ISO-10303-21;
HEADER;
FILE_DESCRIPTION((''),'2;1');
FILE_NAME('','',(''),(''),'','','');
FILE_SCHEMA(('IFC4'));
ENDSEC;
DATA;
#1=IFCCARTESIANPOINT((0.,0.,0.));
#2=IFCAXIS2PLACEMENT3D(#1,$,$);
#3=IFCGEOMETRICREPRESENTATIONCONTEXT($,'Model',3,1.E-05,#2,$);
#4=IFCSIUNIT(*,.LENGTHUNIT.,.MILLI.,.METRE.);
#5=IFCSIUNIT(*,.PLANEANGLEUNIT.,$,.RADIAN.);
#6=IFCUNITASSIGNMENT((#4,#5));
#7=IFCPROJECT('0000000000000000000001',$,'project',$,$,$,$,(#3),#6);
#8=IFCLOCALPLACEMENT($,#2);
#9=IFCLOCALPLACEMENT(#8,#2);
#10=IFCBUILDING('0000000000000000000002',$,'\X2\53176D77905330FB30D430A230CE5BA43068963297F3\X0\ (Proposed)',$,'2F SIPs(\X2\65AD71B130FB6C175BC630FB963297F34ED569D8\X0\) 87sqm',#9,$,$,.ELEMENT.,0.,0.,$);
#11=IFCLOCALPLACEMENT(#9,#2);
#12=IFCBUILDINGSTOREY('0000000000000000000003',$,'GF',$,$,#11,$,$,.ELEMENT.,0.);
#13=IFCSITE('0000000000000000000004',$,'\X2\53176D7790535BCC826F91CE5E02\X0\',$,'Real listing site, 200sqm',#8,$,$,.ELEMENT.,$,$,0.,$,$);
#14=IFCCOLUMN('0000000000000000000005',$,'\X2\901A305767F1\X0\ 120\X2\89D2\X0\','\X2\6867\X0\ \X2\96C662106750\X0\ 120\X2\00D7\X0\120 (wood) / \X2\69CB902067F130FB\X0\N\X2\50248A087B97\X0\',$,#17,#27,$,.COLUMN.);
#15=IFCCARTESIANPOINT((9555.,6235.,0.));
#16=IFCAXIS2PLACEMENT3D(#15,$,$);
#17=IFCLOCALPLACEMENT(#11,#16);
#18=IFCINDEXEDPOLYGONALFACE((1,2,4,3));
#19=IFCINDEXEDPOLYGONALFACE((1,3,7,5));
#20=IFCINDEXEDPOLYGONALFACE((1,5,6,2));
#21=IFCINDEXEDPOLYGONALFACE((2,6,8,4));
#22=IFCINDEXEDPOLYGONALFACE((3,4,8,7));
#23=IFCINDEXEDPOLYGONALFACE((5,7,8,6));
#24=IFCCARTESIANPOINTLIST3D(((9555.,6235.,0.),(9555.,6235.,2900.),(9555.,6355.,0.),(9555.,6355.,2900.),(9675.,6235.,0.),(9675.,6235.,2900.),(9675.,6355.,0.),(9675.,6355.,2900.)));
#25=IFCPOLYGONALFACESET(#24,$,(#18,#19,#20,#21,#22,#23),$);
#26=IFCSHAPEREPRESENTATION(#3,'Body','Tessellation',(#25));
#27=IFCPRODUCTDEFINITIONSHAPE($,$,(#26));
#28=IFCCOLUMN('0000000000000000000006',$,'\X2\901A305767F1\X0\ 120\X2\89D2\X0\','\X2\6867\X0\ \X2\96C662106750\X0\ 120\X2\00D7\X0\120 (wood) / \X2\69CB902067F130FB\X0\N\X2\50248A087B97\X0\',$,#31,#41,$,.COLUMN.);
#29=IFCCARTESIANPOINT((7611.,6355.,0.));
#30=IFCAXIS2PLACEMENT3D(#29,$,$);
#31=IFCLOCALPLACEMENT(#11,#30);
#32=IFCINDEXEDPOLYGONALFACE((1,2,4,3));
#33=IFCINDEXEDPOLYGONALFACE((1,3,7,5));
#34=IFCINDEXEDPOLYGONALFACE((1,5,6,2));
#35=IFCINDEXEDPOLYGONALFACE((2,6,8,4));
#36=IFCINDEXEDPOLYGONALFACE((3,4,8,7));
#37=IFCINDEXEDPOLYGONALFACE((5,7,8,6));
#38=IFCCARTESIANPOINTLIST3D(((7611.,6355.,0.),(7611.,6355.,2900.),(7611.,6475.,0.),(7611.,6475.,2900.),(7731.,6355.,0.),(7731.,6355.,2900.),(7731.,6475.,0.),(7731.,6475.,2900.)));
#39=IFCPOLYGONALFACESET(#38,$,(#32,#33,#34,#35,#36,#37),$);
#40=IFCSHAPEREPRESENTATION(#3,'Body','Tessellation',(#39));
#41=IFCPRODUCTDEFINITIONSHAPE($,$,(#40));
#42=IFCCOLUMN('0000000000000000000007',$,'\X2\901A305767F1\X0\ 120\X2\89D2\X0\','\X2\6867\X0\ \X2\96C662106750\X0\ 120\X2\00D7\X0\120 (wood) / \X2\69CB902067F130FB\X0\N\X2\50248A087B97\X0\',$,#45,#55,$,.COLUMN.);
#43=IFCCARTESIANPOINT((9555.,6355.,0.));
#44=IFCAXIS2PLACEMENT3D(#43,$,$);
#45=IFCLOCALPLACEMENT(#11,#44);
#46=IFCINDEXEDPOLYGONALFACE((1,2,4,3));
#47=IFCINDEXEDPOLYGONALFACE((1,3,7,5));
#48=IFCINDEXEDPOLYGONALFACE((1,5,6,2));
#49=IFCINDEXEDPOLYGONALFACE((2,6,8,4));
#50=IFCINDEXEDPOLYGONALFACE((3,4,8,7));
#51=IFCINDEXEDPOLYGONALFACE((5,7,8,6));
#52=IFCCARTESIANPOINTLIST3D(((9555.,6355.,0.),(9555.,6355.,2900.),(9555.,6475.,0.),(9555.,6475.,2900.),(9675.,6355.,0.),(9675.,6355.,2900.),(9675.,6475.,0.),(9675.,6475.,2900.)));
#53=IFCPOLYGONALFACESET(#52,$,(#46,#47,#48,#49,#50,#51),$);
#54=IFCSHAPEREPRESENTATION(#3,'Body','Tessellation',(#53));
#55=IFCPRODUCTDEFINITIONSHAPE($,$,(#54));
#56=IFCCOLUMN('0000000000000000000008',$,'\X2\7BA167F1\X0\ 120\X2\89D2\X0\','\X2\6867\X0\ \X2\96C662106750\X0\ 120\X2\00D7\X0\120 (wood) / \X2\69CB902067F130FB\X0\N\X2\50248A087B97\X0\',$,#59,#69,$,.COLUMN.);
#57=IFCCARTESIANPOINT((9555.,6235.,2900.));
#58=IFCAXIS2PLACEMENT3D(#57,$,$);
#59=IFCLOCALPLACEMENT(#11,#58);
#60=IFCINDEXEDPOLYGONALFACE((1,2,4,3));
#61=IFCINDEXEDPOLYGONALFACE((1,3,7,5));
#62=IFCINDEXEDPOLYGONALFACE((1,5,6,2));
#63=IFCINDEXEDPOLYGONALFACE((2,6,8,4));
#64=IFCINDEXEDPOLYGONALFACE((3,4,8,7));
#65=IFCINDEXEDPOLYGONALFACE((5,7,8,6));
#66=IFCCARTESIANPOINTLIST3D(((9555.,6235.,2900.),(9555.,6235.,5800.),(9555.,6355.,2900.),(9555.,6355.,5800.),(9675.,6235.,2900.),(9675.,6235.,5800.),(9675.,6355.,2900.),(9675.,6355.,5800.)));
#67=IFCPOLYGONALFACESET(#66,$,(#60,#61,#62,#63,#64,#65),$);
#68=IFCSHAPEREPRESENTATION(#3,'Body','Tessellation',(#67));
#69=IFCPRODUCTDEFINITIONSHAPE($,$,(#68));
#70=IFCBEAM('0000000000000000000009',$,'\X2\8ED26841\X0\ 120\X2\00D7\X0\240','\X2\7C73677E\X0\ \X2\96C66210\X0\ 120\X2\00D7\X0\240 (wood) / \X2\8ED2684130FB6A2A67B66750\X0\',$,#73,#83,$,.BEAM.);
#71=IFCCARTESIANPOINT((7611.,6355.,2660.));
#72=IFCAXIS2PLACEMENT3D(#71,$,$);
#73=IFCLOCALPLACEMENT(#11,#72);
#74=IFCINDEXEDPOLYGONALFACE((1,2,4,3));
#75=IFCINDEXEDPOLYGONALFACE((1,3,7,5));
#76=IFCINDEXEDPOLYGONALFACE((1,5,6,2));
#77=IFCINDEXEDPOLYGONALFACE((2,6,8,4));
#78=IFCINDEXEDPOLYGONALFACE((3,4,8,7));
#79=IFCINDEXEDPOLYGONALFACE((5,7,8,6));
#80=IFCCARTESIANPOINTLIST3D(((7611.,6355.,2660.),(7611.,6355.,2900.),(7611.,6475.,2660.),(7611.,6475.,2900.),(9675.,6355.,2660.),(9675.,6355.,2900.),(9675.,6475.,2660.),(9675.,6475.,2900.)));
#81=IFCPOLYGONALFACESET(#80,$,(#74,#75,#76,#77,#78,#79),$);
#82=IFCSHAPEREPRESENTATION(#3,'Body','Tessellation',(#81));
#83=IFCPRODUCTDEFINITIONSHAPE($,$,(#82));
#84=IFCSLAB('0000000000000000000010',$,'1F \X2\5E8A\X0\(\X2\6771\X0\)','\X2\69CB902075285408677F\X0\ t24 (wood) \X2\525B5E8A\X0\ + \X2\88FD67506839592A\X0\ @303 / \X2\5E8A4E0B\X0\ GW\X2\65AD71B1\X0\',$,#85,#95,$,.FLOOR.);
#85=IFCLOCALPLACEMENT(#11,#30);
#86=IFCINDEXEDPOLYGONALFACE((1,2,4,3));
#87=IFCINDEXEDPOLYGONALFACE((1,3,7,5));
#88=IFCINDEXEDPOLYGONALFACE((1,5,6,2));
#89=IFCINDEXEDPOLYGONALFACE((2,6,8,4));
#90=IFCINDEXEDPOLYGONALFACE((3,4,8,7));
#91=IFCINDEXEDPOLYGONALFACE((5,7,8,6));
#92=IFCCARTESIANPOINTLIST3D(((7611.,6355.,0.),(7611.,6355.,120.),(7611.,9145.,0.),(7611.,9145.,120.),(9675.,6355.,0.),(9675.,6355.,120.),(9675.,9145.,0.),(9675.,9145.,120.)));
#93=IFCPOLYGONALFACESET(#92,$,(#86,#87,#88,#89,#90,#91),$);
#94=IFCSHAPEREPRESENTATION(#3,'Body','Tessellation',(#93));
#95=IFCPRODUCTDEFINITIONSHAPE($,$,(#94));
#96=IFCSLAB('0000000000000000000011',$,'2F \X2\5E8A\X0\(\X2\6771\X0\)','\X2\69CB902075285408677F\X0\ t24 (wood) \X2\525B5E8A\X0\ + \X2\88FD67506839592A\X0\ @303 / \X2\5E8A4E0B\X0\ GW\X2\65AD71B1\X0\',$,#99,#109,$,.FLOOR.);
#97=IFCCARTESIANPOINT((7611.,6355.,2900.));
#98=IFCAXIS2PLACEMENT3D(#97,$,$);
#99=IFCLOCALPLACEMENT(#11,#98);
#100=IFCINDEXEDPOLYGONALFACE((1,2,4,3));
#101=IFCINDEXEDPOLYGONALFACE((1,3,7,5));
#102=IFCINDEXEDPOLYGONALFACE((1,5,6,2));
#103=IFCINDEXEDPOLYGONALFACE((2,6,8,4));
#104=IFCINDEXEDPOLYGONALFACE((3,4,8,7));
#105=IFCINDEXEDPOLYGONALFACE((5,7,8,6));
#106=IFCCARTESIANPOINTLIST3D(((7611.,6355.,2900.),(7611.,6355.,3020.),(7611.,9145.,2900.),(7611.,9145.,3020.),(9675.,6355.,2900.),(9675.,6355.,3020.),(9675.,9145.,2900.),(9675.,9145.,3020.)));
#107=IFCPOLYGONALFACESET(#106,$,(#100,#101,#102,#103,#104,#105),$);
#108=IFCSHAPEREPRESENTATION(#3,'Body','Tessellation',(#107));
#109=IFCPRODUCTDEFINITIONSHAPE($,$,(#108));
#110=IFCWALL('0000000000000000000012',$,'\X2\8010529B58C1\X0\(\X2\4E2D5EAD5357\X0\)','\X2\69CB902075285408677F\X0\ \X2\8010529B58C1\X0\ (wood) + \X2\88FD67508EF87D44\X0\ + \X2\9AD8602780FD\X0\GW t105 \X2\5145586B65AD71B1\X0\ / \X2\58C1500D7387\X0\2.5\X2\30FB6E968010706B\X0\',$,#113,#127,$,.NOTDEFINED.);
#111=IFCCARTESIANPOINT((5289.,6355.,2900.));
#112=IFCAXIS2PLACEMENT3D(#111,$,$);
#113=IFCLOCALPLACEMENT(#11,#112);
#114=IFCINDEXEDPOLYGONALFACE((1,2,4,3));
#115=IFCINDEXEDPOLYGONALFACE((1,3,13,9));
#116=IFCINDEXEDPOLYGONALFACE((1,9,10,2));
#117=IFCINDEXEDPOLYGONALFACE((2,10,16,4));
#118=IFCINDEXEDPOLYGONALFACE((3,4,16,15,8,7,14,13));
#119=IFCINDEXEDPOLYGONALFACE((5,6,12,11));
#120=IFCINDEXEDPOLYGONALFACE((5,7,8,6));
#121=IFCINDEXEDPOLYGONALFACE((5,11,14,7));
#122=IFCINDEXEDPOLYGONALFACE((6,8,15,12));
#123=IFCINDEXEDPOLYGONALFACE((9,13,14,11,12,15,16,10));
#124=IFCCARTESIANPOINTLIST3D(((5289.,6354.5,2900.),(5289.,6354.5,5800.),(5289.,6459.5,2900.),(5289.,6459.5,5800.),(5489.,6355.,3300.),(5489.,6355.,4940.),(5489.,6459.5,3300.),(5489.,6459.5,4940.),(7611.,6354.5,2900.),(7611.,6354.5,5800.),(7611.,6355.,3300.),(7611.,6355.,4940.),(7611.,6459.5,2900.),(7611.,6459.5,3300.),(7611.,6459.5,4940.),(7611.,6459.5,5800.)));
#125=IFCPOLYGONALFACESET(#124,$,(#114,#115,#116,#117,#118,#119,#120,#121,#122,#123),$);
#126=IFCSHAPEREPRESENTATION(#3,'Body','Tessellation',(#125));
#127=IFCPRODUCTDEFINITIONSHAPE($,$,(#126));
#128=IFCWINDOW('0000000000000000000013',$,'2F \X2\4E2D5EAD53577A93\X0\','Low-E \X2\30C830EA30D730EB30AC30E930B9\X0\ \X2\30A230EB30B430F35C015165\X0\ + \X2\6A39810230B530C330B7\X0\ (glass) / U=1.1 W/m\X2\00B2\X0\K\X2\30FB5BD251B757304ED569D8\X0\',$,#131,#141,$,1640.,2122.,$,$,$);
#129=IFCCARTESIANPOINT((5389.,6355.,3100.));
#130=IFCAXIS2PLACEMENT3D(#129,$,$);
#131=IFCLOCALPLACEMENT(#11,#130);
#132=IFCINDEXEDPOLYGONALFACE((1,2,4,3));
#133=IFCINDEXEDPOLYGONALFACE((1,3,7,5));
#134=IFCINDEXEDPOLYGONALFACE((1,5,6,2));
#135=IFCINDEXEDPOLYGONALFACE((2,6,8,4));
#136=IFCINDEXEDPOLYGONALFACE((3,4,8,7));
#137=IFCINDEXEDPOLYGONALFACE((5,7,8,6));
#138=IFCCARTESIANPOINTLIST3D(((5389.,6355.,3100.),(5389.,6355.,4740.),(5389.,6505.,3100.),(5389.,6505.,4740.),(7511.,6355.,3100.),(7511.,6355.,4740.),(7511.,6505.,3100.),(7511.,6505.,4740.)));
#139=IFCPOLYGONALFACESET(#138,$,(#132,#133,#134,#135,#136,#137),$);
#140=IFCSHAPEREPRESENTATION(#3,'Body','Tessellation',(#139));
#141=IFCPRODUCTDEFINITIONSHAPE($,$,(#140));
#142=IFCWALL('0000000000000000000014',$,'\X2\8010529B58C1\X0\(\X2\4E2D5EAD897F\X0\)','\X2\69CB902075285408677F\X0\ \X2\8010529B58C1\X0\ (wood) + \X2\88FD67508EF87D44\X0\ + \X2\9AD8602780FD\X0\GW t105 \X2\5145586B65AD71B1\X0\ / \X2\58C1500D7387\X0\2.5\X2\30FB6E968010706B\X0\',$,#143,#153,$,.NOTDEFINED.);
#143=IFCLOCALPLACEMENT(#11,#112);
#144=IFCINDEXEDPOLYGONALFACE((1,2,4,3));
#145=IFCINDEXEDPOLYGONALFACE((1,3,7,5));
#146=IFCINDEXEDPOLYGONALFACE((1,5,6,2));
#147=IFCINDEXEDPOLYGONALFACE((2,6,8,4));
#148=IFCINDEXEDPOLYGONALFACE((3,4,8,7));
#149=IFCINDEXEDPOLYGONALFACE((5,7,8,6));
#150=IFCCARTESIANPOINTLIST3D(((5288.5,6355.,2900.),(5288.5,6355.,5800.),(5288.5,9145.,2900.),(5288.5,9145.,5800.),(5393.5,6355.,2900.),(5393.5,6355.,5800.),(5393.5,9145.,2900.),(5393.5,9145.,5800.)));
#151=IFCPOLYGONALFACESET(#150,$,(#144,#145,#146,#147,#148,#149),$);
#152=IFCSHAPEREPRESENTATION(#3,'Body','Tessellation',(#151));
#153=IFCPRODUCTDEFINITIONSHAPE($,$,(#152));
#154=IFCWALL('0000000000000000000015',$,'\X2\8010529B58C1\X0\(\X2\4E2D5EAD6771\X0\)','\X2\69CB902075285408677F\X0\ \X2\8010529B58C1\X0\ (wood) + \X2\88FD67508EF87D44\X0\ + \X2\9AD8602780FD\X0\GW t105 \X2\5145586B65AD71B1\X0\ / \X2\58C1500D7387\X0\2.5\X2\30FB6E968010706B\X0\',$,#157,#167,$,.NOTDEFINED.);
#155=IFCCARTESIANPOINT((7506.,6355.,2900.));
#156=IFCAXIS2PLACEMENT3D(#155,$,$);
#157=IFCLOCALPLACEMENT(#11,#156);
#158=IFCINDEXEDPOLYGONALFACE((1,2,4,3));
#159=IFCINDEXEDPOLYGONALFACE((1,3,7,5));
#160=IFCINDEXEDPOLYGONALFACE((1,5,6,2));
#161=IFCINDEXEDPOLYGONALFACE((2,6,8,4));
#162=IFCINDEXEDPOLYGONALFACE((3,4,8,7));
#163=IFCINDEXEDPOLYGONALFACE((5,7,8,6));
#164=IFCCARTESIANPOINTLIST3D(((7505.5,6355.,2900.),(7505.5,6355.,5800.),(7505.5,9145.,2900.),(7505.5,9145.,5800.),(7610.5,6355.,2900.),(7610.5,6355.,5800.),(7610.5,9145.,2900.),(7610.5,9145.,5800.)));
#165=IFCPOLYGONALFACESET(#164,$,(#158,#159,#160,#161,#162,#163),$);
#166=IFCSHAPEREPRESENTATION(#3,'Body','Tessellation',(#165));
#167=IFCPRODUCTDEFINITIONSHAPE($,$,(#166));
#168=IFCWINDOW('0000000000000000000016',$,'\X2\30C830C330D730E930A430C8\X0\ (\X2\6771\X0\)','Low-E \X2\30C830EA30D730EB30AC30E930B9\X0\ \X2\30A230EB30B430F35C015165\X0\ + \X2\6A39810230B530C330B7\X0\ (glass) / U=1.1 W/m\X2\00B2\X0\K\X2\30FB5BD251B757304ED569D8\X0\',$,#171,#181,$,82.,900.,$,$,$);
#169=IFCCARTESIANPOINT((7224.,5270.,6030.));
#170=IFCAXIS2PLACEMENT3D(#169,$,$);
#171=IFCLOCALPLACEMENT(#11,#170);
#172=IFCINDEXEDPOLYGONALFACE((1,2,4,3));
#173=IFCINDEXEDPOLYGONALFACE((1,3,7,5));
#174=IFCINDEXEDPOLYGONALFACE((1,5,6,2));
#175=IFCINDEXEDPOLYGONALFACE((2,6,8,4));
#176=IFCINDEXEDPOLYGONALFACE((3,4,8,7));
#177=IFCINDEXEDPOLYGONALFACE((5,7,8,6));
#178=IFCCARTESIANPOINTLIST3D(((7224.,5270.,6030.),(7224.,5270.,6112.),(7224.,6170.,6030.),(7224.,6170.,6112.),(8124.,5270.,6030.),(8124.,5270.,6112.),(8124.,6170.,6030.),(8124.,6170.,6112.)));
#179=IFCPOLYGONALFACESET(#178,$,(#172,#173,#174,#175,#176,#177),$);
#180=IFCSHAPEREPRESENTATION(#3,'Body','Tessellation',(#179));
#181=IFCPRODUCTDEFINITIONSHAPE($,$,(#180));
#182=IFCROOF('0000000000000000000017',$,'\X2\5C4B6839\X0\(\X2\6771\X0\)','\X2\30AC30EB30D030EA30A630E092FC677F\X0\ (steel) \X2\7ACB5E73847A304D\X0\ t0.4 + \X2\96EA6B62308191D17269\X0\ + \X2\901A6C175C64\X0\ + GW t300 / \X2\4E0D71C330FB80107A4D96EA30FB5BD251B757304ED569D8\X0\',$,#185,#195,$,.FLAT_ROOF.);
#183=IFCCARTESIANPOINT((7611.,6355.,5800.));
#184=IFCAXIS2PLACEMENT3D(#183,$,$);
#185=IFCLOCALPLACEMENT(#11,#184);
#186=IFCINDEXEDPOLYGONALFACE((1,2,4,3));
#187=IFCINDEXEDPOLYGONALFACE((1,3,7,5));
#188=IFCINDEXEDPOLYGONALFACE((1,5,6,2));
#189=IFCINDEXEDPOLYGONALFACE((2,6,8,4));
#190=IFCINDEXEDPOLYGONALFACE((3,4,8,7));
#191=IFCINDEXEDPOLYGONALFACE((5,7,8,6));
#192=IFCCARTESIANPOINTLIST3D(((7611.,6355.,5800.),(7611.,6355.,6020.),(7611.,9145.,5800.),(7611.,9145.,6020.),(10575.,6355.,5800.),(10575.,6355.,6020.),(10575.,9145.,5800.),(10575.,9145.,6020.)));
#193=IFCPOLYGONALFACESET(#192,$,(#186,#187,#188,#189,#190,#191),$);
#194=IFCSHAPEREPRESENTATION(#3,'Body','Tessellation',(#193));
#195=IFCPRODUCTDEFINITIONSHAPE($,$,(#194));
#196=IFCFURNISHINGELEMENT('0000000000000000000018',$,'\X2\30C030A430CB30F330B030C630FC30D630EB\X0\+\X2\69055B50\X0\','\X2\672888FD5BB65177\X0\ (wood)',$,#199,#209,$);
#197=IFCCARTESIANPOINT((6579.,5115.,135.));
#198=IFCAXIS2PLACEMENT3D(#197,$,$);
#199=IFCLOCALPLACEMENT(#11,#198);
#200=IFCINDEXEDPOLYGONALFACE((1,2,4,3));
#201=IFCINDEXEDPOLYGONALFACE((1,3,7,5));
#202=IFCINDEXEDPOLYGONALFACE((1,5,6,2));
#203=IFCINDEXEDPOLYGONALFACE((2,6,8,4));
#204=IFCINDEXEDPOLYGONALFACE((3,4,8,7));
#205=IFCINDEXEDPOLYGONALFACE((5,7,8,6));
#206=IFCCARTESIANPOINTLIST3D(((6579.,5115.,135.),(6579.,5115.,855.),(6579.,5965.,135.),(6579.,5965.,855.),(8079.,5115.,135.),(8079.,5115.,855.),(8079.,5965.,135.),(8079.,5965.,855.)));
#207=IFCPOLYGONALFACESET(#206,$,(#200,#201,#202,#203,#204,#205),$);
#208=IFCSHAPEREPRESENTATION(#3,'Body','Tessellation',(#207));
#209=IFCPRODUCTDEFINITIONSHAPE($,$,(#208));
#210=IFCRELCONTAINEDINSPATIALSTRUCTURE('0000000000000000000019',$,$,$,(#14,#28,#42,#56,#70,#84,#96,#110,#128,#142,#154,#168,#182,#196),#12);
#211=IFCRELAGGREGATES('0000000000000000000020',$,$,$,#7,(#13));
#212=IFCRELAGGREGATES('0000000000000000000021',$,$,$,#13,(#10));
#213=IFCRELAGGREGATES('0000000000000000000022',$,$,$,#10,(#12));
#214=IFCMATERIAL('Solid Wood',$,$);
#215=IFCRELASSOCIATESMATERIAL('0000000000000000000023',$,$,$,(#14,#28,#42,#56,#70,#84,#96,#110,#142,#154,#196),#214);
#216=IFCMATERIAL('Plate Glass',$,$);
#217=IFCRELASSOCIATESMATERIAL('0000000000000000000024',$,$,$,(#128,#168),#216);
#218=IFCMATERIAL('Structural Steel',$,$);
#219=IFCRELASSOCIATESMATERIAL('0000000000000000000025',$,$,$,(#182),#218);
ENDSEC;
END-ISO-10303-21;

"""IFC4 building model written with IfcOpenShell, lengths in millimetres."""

from ifc_helpers import new_model, si_unit, frame, frame_2d, origin, place, context, project, spatial, rectangle, extrude, material, element, fill, save


model = new_model("IFC4")

# Units and contexts
model_context = context("Model", 3, precision=1e-05, world=origin())
ifc_project = project(units=[si_unit("LENGTHUNIT", "METRE", prefix="MILLI"), si_unit("PLANEANGLEUNIT", "RADIAN")], contexts=[model_context])

# Site, building, storey
site_placement = place(None, origin())
site = spatial("IfcSite", under=ifc_project, at=site_placement, Name="北海道富良野市", ObjectType="Real listing site, 200sqm", CompositionType="ELEMENT", RefElevation=0.0)
building_placement = place(site_placement, origin())
building = spatial("IfcBuilding", under=site, at=building_placement, Name="北海道・ピアノ室と防音 (Proposed)", ObjectType="2F SIPs(断熱・気密・防音仕様) 87sqm", CompositionType="ELEMENT", ElevationOfRefHeight=0.0, ElevationOfTerrain=0.0)
storey_placement = place(building_placement, origin())
storey = spatial("IfcBuildingStorey", under=building, at=storey_placement, Name="GF", CompositionType="ELEMENT", Elevation=0.0)

# Columns
ifc_material_1 = material(Name="Solid Wood")
column_1_placement = place(storey_placement, frame((9555.0, 6235.0, 0.0)))
element("IfcColumn", 1, at=column_1_placement, inside=storey, material=ifc_material_1, Name="通し柱 120角", Description="桧 集成材 120×120 (wood) / 構造柱・N値計算", PredefinedType="COLUMN", context=model_context, shape_type="SweptSolid", body=[
    extrude(rectangle(XDim=120.0, YDim=120.0, at=frame_2d((60.0, 60.0))), frame((9555.0, 6235.0, 0.0)), (0.0, 0.0, 1.0), 2900.0),
])
column_2_placement = place(storey_placement, frame((7611.0, 6355.0, 0.0)))
element("IfcColumn", 2, at=column_2_placement, inside=storey, material=ifc_material_1, Name="通し柱 120角", Description="桧 集成材 120×120 (wood) / 構造柱・N値計算", PredefinedType="COLUMN", context=model_context, shape_type="SweptSolid", body=[
    extrude(rectangle(XDim=120.0, YDim=120.0, at=frame_2d((60.0, 60.0))), frame((7611.0, 6355.0, 0.0)), (0.0, 0.0, 1.0), 2900.0),
])
column_3_placement = place(storey_placement, frame((9555.0, 6355.0, 0.0)))
element("IfcColumn", 3, at=column_3_placement, inside=storey, material=ifc_material_1, Name="通し柱 120角", Description="桧 集成材 120×120 (wood) / 構造柱・N値計算", PredefinedType="COLUMN", context=model_context, shape_type="SweptSolid", body=[
    extrude(rectangle(XDim=120.0, YDim=120.0, at=frame_2d((60.0, 60.0))), frame((9555.0, 6355.0, 0.0)), (0.0, 0.0, 1.0), 2900.0),
])
column_4_placement = place(storey_placement, frame((9555.0, 6235.0, 2900.0)))
element("IfcColumn", 4, at=column_4_placement, inside=storey, material=ifc_material_1, Name="管柱 120角", Description="桧 集成材 120×120 (wood) / 構造柱・N値計算", PredefinedType="COLUMN", context=model_context, shape_type="SweptSolid", body=[
    extrude(rectangle(XDim=120.0, YDim=120.0, at=frame_2d((60.0, 60.0))), frame((9555.0, 6235.0, 2900.0)), (0.0, 0.0, 1.0), 2900.0),
])

# Beam
beam_1_placement = place(storey_placement, frame((7611.0, 6355.0, 2660.0)))
element("IfcBeam", 5, at=beam_1_placement, inside=storey, material=ifc_material_1, Name="軒桁 120×240", Description="米松 集成 120×240 (wood) / 軒桁・横架材", PredefinedType="BEAM", context=model_context, shape_type="SweptSolid", body=[
    extrude(rectangle(XDim=2064.0, YDim=120.0, at=frame_2d((1032.0, 60.0))), frame((7611.0, 6355.0, 2660.0)), (0.0, 0.0, 1.0), 240.0),
])

# Slabs
slab_1_placement = place(storey_placement, frame((7611.0, 6355.0, 0.0)))
element("IfcSlab", 6, at=slab_1_placement, inside=storey, material=ifc_material_1, Name="1F 床(東)", Description="構造用合板 t24 (wood) 剛床 + 製材根太 @303 / 床下 GW断熱", PredefinedType="FLOOR", context=model_context, shape_type="SweptSolid", body=[
    extrude(rectangle(XDim=2064.0, YDim=2790.0, at=frame_2d((1032.0, 1395.0))), frame((7611.0, 6355.0, 0.0)), (0.0, 0.0, 1.0), 120.0),
])
slab_2_placement = place(storey_placement, frame((7611.0, 6355.0, 2900.0)))
element("IfcSlab", 7, at=slab_2_placement, inside=storey, material=ifc_material_1, Name="2F 床(東)", Description="構造用合板 t24 (wood) 剛床 + 製材根太 @303 / 床下 GW断熱", PredefinedType="FLOOR", context=model_context, shape_type="SweptSolid", body=[
    extrude(rectangle(XDim=2064.0, YDim=2790.0, at=frame_2d((1032.0, 1395.0))), frame((7611.0, 6355.0, 2900.0)), (0.0, 0.0, 1.0), 120.0),
])

# Wall, opening, window
wall_1_placement = place(storey_placement, frame((5289.0, 6355.0, 2900.0)))
wall_1 = element("IfcWall", 8, at=wall_1_placement, inside=storey, material=ifc_material_1, Name="耐力壁(中庭南)", Description="構造用合板 耐力壁 (wood) + 製材軸組 + 高性能GW t105 充填断熱 / 壁倍率2.5・準耐火", PredefinedType="NOTDEFINED", context=model_context, shape_type="SweptSolid", body=[
    extrude(rectangle(XDim=2322.0, YDim=105.0, at=frame_2d((1161.0, 52.0))), frame((5289.0, 6355.0, 2900.0)), (0.0, 0.0, 1.0), 2900.0),
])
opening_placement = place(storey_placement, frame((5389.0, 6355.0, 3100.0)))
opening = element("IfcOpeningElement", 9, at=opening_placement, cuts=wall_1, PredefinedType="NOTDEFINED", context=model_context, shape_type="SweptSolid", body=[
    extrude(rectangle(XDim=2122.0, YDim=150.0, at=frame_2d((1061.0, 75.0))), frame((5389.0, 6355.0, 3100.0)), (0.0, 0.0, 1.0), 1640.0),
])
ifc_material_2 = material(Name="Plate Glass")
window_1_placement = place(storey_placement, frame((5389.0, 6355.0, 3100.0)))
window_1 = element("IfcWindow", 10, at=window_1_placement, inside=storey, material=ifc_material_2, Name="2F 中庭南窓", Description="Low-E トリプルガラス アルゴン封入 + 樹脂サッシ (glass) / U=1.1 W/m²K・寒冷地仕様", OverallHeight=1640.0, OverallWidth=2122.0, context=model_context, shape_type="SweptSolid", body=[
    extrude(rectangle(XDim=2122.0, YDim=150.0, at=frame_2d((1061.0, 75.0))), frame((5389.0, 6355.0, 3100.0)), (0.0, 0.0, 1.0), 1640.0),
])
fill(opening, window_1)

# Walls
wall_2_placement = place(storey_placement, frame((5289.0, 6355.0, 2900.0)))
element("IfcWall", 11, at=wall_2_placement, inside=storey, material=ifc_material_1, Name="耐力壁(中庭西)", Description="構造用合板 耐力壁 (wood) + 製材軸組 + 高性能GW t105 充填断熱 / 壁倍率2.5・準耐火", PredefinedType="NOTDEFINED", context=model_context, shape_type="SweptSolid", body=[
    extrude(rectangle(XDim=105.0, YDim=2790.0, at=frame_2d((52.0, 1395.0))), frame((5289.0, 6355.0, 2900.0)), (0.0, 0.0, 1.0), 2900.0),
])
wall_3_placement = place(storey_placement, frame((7506.0, 6355.0, 2900.0)))
element("IfcWall", 12, at=wall_3_placement, inside=storey, material=ifc_material_1, Name="耐力壁(中庭東)", Description="構造用合板 耐力壁 (wood) + 製材軸組 + 高性能GW t105 充填断熱 / 壁倍率2.5・準耐火", PredefinedType="NOTDEFINED", context=model_context, shape_type="SweptSolid", body=[
    extrude(rectangle(XDim=105.0, YDim=2790.0, at=frame_2d((52.0, 1395.0))), frame((7506.0, 6355.0, 2900.0)), (0.0, 0.0, 1.0), 2900.0),
])

# Window
window_2_placement = place(storey_placement, frame((7224.0, 5270.0, 6030.0)))
element("IfcWindow", 13, at=window_2_placement, inside=storey, material=ifc_material_2, Name="トップライト (東)", Description="Low-E トリプルガラス アルゴン封入 + 樹脂サッシ (glass) / U=1.1 W/m²K・寒冷地仕様", OverallHeight=82.0, OverallWidth=900.0, context=model_context, shape_type="SweptSolid", body=[
    extrude(rectangle(XDim=900.0, YDim=900.0, at=frame_2d((450.0, 450.0))), frame((7224.0, 5270.0, 6030.0)), (0.0, 0.0, 1.0), 82.0),
])

# Roof
ifc_material_3 = material(Name="Structural Steel")
for number, where, name in (
    (14, (7611.0, 6355.0, 5800.0), "屋根(東)"),
):
    element("IfcRoof", number, at=place(storey_placement, frame(where)), inside=storey, material=ifc_material_3, Name=name, Description="ガルバリウム鋼板 (steel) 立平葺き t0.4 + 雪止め金物 + 通気層 + GW t300 / 不燃・耐積雪・寒冷地仕様", PredefinedType="FLAT_ROOF", context=model_context, shape_type="SweptSolid", body=[
        extrude(rectangle(XDim=2964.0, YDim=2790.0, at=frame_2d((1482.0, 1395.0))), frame((7611.0, 6355.0, 5800.0)), (0.0, 0.0, 1.0), 220.0),
    ])

# Furnishing element
furnishing_1_placement = place(storey_placement, frame((6579.0, 5115.0, 135.0)))
element("IfcFurnishingElement", 15, at=furnishing_1_placement, inside=storey, material=ifc_material_1, Name="ダイニングテーブル+椅子", Description="木製家具 (wood)", context=model_context, shape_type="SweptSolid", body=[
    extrude(rectangle(XDim=1500.0, YDim=850.0, at=frame_2d((750.0, 425.0))), frame((6579.0, 5115.0, 135.0)), (0.0, 0.0, 1.0), 720.0),
])

save(model, "model.ifc")
